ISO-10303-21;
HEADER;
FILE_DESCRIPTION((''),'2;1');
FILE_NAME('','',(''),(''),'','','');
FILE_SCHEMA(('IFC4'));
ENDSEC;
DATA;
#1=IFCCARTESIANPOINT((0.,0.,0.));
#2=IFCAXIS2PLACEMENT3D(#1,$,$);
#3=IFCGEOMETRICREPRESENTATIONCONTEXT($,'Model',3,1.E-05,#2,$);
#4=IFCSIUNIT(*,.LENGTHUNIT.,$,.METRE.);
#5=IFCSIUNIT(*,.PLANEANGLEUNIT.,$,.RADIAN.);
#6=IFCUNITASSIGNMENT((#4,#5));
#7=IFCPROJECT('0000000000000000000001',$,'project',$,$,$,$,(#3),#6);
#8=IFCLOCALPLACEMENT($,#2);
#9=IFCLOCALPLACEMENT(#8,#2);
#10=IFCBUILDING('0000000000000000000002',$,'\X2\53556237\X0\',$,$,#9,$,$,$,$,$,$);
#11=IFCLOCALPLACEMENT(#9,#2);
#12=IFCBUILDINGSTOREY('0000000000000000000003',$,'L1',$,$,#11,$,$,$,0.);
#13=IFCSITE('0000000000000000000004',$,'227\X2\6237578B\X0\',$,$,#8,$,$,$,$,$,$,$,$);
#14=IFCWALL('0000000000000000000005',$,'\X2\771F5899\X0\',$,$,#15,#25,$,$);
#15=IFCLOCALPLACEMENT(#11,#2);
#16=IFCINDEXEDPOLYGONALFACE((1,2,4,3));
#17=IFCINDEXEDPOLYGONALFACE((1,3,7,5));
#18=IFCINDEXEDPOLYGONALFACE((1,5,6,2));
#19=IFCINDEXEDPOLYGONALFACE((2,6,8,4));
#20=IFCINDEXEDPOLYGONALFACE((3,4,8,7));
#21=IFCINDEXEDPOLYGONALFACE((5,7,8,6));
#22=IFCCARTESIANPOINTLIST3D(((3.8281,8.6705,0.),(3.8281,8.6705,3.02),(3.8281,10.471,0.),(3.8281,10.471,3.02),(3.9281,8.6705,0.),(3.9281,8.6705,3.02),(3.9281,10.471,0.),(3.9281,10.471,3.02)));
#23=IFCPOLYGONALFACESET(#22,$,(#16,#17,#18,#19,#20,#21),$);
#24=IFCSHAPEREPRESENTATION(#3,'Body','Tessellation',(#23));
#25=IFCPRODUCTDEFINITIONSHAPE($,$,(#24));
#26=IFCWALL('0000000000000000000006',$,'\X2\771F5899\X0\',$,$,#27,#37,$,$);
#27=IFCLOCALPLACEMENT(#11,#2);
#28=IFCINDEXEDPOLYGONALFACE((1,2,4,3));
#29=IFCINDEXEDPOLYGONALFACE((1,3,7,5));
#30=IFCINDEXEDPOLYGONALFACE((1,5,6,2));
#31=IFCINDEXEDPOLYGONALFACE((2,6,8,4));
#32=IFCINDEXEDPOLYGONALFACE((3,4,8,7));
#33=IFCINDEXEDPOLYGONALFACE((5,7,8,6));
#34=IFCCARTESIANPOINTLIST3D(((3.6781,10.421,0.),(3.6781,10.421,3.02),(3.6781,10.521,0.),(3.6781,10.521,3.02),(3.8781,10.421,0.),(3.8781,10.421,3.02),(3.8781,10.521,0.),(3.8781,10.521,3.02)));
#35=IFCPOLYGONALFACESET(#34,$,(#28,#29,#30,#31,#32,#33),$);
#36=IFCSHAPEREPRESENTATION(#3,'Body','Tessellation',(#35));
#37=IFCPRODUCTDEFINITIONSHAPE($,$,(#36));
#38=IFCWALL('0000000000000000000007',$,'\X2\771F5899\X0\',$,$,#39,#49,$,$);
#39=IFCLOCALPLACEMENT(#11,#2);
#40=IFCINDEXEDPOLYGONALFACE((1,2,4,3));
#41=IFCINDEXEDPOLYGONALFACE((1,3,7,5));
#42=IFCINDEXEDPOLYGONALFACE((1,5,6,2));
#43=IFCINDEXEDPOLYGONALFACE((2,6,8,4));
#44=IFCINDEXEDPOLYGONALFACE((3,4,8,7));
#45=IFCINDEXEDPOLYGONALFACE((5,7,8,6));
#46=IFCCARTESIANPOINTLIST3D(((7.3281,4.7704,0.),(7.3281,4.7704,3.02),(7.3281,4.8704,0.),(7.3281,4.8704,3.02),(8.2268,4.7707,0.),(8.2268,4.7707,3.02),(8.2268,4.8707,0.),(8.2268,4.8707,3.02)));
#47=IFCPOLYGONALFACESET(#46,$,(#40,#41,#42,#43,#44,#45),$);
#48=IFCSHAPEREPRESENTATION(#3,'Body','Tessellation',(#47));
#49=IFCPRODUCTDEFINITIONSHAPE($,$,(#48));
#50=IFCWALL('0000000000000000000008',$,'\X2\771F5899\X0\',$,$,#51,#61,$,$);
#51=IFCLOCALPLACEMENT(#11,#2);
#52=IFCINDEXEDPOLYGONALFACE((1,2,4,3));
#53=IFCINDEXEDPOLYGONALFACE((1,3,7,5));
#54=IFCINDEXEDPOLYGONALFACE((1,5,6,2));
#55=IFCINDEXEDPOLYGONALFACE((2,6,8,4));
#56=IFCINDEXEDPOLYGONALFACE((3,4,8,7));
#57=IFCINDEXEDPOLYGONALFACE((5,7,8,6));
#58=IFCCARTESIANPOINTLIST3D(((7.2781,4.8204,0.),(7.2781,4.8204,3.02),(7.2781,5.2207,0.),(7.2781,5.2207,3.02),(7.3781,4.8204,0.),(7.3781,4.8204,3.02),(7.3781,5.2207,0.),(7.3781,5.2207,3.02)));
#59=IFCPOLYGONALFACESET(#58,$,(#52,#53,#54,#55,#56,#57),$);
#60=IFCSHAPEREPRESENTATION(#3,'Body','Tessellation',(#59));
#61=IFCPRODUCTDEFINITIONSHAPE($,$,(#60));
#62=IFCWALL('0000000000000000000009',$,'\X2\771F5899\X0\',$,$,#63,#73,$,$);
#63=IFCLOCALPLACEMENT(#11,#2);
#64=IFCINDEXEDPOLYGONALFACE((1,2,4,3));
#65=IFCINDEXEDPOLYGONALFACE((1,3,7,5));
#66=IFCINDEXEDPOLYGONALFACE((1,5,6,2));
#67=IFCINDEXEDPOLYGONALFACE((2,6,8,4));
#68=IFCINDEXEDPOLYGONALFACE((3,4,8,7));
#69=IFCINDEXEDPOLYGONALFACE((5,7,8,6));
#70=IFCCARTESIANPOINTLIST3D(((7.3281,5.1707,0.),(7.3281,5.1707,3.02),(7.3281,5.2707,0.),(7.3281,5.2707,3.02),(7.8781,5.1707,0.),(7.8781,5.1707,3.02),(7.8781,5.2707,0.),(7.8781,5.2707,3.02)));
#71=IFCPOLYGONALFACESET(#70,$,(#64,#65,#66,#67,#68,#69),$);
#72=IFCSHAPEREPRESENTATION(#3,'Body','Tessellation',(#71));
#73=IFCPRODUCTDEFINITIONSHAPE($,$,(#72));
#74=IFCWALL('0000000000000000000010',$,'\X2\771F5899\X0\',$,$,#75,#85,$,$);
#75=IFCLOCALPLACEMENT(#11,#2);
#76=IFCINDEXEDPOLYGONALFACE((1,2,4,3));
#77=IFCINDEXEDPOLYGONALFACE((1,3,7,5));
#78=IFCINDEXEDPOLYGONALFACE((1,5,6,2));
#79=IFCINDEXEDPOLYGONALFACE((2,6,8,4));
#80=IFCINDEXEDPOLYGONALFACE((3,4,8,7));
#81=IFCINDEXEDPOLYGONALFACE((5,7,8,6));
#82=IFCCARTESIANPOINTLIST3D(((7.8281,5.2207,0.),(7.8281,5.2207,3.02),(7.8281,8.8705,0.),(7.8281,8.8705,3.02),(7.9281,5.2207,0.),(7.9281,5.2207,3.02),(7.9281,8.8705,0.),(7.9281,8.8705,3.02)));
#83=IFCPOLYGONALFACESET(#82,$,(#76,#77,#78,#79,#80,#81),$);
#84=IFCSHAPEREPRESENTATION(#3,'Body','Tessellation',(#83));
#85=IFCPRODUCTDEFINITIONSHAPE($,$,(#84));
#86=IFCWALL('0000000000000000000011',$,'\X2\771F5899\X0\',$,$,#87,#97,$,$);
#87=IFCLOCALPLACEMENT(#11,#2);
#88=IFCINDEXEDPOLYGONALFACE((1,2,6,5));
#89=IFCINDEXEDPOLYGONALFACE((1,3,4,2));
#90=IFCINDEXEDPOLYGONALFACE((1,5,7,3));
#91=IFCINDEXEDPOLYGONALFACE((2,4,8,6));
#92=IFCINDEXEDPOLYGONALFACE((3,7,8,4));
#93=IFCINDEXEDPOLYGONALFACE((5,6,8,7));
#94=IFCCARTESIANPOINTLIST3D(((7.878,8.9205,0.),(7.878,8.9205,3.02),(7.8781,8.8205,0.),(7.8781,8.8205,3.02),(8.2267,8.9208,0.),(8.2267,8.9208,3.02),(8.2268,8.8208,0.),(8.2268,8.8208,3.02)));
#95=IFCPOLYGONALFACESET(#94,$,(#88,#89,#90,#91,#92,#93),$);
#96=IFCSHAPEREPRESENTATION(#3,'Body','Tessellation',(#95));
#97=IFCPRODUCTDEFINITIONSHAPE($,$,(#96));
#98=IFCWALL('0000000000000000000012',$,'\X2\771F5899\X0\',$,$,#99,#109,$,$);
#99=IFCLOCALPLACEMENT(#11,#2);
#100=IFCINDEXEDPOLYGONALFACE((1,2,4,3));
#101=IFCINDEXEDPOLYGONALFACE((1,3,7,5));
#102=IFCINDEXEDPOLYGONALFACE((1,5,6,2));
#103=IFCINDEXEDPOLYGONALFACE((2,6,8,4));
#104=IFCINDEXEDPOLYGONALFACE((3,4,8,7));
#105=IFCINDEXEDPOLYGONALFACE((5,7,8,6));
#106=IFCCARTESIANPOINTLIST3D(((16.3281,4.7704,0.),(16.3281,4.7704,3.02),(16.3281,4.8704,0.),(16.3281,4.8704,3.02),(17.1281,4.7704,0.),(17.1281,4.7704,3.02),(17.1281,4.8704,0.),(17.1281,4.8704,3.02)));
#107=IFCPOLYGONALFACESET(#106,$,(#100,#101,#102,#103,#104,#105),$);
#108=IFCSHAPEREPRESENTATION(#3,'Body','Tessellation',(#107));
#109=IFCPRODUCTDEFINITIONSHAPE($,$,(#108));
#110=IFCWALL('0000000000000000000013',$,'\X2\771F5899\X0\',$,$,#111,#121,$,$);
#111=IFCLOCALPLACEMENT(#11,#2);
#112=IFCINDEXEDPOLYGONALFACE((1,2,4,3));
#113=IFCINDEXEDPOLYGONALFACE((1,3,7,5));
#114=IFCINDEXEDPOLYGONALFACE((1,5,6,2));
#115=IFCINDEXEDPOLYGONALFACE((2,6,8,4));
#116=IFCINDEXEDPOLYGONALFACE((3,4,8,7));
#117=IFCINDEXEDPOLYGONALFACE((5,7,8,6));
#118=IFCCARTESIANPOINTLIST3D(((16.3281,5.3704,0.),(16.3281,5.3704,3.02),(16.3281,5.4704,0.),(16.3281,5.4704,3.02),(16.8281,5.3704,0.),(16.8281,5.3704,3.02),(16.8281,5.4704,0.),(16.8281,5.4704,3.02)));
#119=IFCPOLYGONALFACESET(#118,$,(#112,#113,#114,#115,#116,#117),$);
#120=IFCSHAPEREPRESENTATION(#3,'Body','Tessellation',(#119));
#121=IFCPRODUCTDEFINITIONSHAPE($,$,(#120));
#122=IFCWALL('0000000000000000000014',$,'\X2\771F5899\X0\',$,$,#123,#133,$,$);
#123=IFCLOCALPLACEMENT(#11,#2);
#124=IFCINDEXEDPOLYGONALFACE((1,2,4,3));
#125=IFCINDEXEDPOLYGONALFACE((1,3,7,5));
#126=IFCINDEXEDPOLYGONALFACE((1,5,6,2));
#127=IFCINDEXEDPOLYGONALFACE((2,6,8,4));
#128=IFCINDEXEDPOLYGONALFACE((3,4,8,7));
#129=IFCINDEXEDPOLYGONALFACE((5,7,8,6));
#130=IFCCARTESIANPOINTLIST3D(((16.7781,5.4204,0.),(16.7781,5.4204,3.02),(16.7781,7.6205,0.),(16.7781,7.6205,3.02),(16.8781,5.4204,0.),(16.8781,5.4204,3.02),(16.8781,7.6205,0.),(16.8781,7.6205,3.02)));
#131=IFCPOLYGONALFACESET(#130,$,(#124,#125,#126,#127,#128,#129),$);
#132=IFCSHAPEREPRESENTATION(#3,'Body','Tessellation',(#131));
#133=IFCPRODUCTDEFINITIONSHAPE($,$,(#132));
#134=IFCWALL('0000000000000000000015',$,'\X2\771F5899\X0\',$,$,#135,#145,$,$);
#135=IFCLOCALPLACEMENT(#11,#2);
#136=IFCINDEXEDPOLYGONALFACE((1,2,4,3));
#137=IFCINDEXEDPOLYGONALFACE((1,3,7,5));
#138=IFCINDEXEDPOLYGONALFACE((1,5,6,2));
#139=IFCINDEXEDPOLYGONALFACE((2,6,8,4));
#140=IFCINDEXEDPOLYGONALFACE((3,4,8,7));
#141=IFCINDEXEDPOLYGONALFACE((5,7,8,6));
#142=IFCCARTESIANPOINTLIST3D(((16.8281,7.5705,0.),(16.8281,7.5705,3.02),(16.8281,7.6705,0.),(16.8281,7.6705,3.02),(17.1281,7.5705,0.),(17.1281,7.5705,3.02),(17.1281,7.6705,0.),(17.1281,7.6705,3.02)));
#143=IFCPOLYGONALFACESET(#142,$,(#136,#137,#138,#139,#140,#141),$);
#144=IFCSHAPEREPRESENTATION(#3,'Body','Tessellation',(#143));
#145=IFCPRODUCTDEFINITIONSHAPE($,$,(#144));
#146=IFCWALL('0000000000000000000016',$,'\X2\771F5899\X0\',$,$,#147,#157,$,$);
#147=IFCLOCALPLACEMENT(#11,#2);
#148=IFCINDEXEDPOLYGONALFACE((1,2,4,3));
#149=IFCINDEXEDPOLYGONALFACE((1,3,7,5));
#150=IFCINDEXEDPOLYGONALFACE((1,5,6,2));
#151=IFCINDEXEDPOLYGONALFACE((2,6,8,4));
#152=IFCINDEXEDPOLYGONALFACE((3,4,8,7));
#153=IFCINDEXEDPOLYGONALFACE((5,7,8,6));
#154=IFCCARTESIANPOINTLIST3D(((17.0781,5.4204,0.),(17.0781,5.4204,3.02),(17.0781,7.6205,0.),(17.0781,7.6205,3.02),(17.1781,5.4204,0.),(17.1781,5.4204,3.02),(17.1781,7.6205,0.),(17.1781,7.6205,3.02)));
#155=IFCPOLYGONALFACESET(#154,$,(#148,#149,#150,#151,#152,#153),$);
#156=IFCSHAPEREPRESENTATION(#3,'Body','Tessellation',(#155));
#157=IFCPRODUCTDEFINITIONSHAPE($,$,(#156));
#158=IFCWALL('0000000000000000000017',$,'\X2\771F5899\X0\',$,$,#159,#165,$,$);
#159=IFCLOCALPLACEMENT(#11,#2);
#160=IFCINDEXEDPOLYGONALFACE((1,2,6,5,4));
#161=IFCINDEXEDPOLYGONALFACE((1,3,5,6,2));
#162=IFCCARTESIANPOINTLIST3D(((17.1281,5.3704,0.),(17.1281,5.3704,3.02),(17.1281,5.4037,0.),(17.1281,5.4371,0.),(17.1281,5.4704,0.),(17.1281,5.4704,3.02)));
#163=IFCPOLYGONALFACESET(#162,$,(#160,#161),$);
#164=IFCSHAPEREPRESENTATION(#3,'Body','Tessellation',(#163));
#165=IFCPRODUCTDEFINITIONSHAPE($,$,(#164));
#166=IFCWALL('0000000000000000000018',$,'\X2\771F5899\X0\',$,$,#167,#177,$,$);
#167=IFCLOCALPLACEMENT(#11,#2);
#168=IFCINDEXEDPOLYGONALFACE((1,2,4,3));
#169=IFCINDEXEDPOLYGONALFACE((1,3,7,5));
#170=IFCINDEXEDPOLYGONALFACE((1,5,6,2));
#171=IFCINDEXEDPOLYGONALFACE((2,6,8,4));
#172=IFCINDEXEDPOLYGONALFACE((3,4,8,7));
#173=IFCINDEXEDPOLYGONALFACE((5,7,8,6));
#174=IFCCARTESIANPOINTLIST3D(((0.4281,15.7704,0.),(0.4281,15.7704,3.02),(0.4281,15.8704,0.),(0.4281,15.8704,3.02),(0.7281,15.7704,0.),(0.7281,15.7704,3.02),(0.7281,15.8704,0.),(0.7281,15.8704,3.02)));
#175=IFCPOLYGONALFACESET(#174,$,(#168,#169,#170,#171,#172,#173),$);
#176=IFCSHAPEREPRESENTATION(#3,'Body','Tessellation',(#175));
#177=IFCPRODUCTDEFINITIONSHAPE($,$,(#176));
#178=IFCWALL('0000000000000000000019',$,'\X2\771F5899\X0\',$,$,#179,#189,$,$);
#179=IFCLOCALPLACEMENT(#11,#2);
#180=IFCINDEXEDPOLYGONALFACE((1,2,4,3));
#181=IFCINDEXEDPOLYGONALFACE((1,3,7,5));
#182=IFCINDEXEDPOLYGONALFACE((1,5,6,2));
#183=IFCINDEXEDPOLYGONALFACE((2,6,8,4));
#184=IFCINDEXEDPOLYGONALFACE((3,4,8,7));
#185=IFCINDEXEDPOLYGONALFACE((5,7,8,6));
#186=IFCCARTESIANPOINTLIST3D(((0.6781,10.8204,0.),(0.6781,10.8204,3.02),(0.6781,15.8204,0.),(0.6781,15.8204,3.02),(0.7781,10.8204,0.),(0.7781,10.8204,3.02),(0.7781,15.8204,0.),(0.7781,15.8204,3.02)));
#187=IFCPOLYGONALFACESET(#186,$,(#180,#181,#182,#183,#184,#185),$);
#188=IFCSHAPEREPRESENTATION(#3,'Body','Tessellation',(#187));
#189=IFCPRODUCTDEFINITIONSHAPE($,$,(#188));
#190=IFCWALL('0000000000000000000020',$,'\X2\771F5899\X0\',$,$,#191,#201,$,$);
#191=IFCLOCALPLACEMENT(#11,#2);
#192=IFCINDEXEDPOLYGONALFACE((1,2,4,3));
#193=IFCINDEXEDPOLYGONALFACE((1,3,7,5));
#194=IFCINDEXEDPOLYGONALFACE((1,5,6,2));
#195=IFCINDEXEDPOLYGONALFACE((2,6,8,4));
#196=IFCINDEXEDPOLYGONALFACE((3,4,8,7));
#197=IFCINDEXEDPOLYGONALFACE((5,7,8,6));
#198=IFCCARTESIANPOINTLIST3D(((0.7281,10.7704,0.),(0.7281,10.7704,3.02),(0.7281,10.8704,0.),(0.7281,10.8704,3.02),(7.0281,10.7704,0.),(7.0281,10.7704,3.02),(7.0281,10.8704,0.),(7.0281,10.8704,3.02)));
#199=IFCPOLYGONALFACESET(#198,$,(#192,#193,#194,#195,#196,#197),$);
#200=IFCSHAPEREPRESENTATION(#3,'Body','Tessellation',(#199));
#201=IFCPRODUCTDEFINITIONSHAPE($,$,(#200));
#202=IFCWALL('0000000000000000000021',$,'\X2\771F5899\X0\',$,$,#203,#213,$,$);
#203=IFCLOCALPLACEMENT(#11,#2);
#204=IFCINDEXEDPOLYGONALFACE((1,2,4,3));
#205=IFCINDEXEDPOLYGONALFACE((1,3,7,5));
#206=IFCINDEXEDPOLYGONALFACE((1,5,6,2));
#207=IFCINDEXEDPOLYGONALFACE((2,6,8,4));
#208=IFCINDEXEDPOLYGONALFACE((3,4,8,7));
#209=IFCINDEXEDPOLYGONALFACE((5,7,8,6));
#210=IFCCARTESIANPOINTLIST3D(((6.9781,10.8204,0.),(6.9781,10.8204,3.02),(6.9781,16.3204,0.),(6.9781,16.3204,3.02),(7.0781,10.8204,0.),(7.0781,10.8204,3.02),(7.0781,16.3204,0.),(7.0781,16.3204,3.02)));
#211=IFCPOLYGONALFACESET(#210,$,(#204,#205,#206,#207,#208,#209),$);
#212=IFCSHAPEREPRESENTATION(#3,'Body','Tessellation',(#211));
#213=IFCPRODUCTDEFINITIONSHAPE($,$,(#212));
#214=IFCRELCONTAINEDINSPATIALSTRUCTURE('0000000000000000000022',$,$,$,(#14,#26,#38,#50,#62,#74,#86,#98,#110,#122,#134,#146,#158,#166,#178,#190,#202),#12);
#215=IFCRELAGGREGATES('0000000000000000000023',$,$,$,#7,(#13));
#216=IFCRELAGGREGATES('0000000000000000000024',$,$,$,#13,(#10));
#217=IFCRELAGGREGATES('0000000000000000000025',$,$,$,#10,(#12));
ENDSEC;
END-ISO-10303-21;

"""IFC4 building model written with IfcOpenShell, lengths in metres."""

from ifc_helpers import new_model, si_unit, origin, place, context, project, spatial, polyline, outline, extrude, element, save


model = new_model("IFC4")

# Units and contexts
model_context = context("Model", 3, precision=1e-05, world=origin())
ifc_project = project(units=[si_unit("LENGTHUNIT", "METRE"), si_unit("PLANEANGLEUNIT", "RADIAN")], contexts=[model_context])

# Site, building, storey
site_placement = place(None, origin())
site = spatial("IfcSite", under=ifc_project, at=site_placement, Name="227户型")
building_placement = place(site_placement, origin())
building = spatial("IfcBuilding", under=site, at=building_placement, Name="单户")
storey_placement = place(building_placement, origin())
storey = spatial("IfcBuildingStorey", under=building, at=storey_placement, Name="L1", Elevation=0.0)

# Walls
wall_1_placement = place(storey_placement, origin())
element("IfcWall", 1, at=wall_1_placement, inside=storey, Name="真墙", context=model_context, shape_type="SweptSolid", body=[
    extrude(outline(polyline([(3.8281, 8.6705), (3.8281, 10.471), (3.9281, 10.471), (3.9281, 8.6705), (3.8281, 8.6705)])), origin(), (0.0, 0.0, 1.0), 3.02),
])
wall_2_placement = place(storey_placement, origin())
element("IfcWall", 2, at=wall_2_placement, inside=storey, Name="真墙", context=model_context, shape_type="SweptSolid", body=[
    extrude(outline(polyline([(3.8781, 10.421), (3.6781, 10.421), (3.6781, 10.521), (3.8781, 10.521), (3.8781, 10.421)])), origin(), (0.0, 0.0, 1.0), 3.02),
])
wall_3_placement = place(storey_placement, origin())
element("IfcWall", 3, at=wall_3_placement, inside=storey, Name="真墙", context=model_context, shape_type="SweptSolid", body=[
    extrude(outline(polyline([(8.2268, 4.7707), (7.3281, 4.7704), (7.3281, 4.8704), (8.2268, 4.8707), (8.2268, 4.7707)])), origin(), (0.0, 0.0, 1.0), 3.02),
])
wall_4_placement = place(storey_placement, origin())
element("IfcWall", 4, at=wall_4_placement, inside=storey, Name="真墙", context=model_context, shape_type="SweptSolid", body=[
    extrude(outline(polyline([(7.2781, 4.8204), (7.2781, 5.2207), (7.3781, 5.2207), (7.3781, 4.8204), (7.2781, 4.8204)])), origin(), (0.0, 0.0, 1.0), 3.02),
])
wall_5_placement = place(storey_placement, origin())
element("IfcWall", 5, at=wall_5_placement, inside=storey, Name="真墙", context=model_context, shape_type="SweptSolid", body=[
    extrude(outline(polyline([(7.3281, 5.2707), (7.8781, 5.2707), (7.8781, 5.1707), (7.3281, 5.1707), (7.3281, 5.2707)])), origin(), (0.0, 0.0, 1.0), 3.02),
])
wall_6_placement = place(storey_placement, origin())
element("IfcWall", 6, at=wall_6_placement, inside=storey, Name="真墙", context=model_context, shape_type="SweptSolid", body=[
    extrude(outline(polyline([(7.8281, 5.2207), (7.8281, 8.8705), (7.9281, 8.8705), (7.9281, 5.2207), (7.8281, 5.2207)])), origin(), (0.0, 0.0, 1.0), 3.02),
])
wall_7_placement = place(storey_placement, origin())
element("IfcWall", 7, at=wall_7_placement, inside=storey, Name="真墙", context=model_context, shape_type="SweptSolid", body=[
    extrude(outline(polyline([(7.878, 8.9205), (8.2267, 8.9208), (8.2268, 8.8208), (7.8781, 8.8205), (7.878, 8.9205)])), origin(), (0.0, 0.0, 1.0), 3.02),
])

# Wall
wall_8_placement = place(storey_placement, origin())
element("IfcWall", 8, at=wall_8_placement, inside=storey, Name="真墙", context=model_context, shape_type="SweptSolid", body=[
    extrude(outline(polyline([(17.1281, 4.7704), (16.3281, 4.7704), (16.3281, 4.8704), (17.1281, 4.8704), (17.1281, 4.7704)])), origin(), (0.0, 0.0, 1.0), 3.02),
])

# Walls
wall_9_placement = place(storey_placement, origin())
element("IfcWall", 9, at=wall_9_placement, inside=storey, Name="真墙", context=model_context, shape_type="SweptSolid", body=[
    extrude(outline(polyline([(16.3281, 5.4704), (16.8281, 5.4704), (16.8281, 5.3704), (16.3281, 5.3704), (16.3281, 5.4704)])), origin(), (0.0, 0.0, 1.0), 3.02),
])
wall_10_placement = place(storey_placement, origin())
element("IfcWall", 10, at=wall_10_placement, inside=storey, Name="真墙", context=model_context, shape_type="SweptSolid", body=[
    extrude(outline(polyline([(16.7781, 5.4204), (16.7781, 7.6205), (16.8781, 7.6205), (16.8781, 5.4204), (16.7781, 5.4204)])), origin(), (0.0, 0.0, 1.0), 3.02),
])
wall_11_placement = place(storey_placement, origin())
element("IfcWall", 11, at=wall_11_placement, inside=storey, Name="真墙", context=model_context, shape_type="SweptSolid", body=[
    extrude(outline(polyline([(16.8281, 7.6705), (17.1281, 7.6705), (17.1281, 7.5705), (16.8281, 7.5705), (16.8281, 7.6705)])), origin(), (0.0, 0.0, 1.0), 3.02),
])
wall_12_placement = place(storey_placement, origin())
element("IfcWall", 12, at=wall_12_placement, inside=storey, Name="真墙", context=model_context, shape_type="SweptSolid", body=[
    extrude(outline(polyline([(17.1781, 7.6205), (17.1781, 5.4204), (17.0781, 5.4204), (17.0781, 7.6205), (17.1781, 7.6205)])), origin(), (0.0, 0.0, 1.0), 3.02),
])
wall_13_placement = place(storey_placement, origin())
element("IfcWall", 13, at=wall_13_placement, inside=storey, Name="真墙", context=model_context, shape_type="SweptSolid", body=[
    extrude(outline(polyline([(17.1281, 5.4704), (17.1281, 5.4704), (17.1281, 5.3704), (17.1281, 5.3704), (17.1281, 5.4704)])), origin(), (0.0, 0.0, 1.0), 3.02),
])
wall_14_placement = place(storey_placement, origin())
element("IfcWall", 14, at=wall_14_placement, inside=storey, Name="真墙", context=model_context, shape_type="SweptSolid", body=[
    extrude(outline(polyline([(0.4281, 15.8704), (0.7281, 15.8704), (0.7281, 15.7704), (0.4281, 15.7704), (0.4281, 15.8704)])), origin(), (0.0, 0.0, 1.0), 3.02),
])
wall_15_placement = place(storey_placement, origin())
element("IfcWall", 15, at=wall_15_placement, inside=storey, Name="真墙", context=model_context, shape_type="SweptSolid", body=[
    extrude(outline(polyline([(0.7781, 15.8204), (0.7781, 10.8204), (0.6781, 10.8204), (0.6781, 15.8204), (0.7781, 15.8204)])), origin(), (0.0, 0.0, 1.0), 3.02),
])
wall_16_placement = place(storey_placement, origin())
element("IfcWall", 16, at=wall_16_placement, inside=storey, Name="真墙", context=model_context, shape_type="SweptSolid", body=[
    extrude(outline(polyline([(0.7281, 10.8704), (7.0281, 10.8704), (7.0281, 10.7704), (0.7281, 10.7704), (0.7281, 10.8704)])), origin(), (0.0, 0.0, 1.0), 3.02),
])
wall_17_placement = place(storey_placement, origin())
element("IfcWall", 17, at=wall_17_placement, inside=storey, Name="真墙", context=model_context, shape_type="SweptSolid", body=[
    extrude(outline(polyline([(6.9781, 10.8204), (6.9781, 16.3204), (7.0781, 16.3204), (7.0781, 10.8204), (6.9781, 10.8204)])), origin(), (0.0, 0.0, 1.0), 3.02),
])

save(model, "model.ifc")
